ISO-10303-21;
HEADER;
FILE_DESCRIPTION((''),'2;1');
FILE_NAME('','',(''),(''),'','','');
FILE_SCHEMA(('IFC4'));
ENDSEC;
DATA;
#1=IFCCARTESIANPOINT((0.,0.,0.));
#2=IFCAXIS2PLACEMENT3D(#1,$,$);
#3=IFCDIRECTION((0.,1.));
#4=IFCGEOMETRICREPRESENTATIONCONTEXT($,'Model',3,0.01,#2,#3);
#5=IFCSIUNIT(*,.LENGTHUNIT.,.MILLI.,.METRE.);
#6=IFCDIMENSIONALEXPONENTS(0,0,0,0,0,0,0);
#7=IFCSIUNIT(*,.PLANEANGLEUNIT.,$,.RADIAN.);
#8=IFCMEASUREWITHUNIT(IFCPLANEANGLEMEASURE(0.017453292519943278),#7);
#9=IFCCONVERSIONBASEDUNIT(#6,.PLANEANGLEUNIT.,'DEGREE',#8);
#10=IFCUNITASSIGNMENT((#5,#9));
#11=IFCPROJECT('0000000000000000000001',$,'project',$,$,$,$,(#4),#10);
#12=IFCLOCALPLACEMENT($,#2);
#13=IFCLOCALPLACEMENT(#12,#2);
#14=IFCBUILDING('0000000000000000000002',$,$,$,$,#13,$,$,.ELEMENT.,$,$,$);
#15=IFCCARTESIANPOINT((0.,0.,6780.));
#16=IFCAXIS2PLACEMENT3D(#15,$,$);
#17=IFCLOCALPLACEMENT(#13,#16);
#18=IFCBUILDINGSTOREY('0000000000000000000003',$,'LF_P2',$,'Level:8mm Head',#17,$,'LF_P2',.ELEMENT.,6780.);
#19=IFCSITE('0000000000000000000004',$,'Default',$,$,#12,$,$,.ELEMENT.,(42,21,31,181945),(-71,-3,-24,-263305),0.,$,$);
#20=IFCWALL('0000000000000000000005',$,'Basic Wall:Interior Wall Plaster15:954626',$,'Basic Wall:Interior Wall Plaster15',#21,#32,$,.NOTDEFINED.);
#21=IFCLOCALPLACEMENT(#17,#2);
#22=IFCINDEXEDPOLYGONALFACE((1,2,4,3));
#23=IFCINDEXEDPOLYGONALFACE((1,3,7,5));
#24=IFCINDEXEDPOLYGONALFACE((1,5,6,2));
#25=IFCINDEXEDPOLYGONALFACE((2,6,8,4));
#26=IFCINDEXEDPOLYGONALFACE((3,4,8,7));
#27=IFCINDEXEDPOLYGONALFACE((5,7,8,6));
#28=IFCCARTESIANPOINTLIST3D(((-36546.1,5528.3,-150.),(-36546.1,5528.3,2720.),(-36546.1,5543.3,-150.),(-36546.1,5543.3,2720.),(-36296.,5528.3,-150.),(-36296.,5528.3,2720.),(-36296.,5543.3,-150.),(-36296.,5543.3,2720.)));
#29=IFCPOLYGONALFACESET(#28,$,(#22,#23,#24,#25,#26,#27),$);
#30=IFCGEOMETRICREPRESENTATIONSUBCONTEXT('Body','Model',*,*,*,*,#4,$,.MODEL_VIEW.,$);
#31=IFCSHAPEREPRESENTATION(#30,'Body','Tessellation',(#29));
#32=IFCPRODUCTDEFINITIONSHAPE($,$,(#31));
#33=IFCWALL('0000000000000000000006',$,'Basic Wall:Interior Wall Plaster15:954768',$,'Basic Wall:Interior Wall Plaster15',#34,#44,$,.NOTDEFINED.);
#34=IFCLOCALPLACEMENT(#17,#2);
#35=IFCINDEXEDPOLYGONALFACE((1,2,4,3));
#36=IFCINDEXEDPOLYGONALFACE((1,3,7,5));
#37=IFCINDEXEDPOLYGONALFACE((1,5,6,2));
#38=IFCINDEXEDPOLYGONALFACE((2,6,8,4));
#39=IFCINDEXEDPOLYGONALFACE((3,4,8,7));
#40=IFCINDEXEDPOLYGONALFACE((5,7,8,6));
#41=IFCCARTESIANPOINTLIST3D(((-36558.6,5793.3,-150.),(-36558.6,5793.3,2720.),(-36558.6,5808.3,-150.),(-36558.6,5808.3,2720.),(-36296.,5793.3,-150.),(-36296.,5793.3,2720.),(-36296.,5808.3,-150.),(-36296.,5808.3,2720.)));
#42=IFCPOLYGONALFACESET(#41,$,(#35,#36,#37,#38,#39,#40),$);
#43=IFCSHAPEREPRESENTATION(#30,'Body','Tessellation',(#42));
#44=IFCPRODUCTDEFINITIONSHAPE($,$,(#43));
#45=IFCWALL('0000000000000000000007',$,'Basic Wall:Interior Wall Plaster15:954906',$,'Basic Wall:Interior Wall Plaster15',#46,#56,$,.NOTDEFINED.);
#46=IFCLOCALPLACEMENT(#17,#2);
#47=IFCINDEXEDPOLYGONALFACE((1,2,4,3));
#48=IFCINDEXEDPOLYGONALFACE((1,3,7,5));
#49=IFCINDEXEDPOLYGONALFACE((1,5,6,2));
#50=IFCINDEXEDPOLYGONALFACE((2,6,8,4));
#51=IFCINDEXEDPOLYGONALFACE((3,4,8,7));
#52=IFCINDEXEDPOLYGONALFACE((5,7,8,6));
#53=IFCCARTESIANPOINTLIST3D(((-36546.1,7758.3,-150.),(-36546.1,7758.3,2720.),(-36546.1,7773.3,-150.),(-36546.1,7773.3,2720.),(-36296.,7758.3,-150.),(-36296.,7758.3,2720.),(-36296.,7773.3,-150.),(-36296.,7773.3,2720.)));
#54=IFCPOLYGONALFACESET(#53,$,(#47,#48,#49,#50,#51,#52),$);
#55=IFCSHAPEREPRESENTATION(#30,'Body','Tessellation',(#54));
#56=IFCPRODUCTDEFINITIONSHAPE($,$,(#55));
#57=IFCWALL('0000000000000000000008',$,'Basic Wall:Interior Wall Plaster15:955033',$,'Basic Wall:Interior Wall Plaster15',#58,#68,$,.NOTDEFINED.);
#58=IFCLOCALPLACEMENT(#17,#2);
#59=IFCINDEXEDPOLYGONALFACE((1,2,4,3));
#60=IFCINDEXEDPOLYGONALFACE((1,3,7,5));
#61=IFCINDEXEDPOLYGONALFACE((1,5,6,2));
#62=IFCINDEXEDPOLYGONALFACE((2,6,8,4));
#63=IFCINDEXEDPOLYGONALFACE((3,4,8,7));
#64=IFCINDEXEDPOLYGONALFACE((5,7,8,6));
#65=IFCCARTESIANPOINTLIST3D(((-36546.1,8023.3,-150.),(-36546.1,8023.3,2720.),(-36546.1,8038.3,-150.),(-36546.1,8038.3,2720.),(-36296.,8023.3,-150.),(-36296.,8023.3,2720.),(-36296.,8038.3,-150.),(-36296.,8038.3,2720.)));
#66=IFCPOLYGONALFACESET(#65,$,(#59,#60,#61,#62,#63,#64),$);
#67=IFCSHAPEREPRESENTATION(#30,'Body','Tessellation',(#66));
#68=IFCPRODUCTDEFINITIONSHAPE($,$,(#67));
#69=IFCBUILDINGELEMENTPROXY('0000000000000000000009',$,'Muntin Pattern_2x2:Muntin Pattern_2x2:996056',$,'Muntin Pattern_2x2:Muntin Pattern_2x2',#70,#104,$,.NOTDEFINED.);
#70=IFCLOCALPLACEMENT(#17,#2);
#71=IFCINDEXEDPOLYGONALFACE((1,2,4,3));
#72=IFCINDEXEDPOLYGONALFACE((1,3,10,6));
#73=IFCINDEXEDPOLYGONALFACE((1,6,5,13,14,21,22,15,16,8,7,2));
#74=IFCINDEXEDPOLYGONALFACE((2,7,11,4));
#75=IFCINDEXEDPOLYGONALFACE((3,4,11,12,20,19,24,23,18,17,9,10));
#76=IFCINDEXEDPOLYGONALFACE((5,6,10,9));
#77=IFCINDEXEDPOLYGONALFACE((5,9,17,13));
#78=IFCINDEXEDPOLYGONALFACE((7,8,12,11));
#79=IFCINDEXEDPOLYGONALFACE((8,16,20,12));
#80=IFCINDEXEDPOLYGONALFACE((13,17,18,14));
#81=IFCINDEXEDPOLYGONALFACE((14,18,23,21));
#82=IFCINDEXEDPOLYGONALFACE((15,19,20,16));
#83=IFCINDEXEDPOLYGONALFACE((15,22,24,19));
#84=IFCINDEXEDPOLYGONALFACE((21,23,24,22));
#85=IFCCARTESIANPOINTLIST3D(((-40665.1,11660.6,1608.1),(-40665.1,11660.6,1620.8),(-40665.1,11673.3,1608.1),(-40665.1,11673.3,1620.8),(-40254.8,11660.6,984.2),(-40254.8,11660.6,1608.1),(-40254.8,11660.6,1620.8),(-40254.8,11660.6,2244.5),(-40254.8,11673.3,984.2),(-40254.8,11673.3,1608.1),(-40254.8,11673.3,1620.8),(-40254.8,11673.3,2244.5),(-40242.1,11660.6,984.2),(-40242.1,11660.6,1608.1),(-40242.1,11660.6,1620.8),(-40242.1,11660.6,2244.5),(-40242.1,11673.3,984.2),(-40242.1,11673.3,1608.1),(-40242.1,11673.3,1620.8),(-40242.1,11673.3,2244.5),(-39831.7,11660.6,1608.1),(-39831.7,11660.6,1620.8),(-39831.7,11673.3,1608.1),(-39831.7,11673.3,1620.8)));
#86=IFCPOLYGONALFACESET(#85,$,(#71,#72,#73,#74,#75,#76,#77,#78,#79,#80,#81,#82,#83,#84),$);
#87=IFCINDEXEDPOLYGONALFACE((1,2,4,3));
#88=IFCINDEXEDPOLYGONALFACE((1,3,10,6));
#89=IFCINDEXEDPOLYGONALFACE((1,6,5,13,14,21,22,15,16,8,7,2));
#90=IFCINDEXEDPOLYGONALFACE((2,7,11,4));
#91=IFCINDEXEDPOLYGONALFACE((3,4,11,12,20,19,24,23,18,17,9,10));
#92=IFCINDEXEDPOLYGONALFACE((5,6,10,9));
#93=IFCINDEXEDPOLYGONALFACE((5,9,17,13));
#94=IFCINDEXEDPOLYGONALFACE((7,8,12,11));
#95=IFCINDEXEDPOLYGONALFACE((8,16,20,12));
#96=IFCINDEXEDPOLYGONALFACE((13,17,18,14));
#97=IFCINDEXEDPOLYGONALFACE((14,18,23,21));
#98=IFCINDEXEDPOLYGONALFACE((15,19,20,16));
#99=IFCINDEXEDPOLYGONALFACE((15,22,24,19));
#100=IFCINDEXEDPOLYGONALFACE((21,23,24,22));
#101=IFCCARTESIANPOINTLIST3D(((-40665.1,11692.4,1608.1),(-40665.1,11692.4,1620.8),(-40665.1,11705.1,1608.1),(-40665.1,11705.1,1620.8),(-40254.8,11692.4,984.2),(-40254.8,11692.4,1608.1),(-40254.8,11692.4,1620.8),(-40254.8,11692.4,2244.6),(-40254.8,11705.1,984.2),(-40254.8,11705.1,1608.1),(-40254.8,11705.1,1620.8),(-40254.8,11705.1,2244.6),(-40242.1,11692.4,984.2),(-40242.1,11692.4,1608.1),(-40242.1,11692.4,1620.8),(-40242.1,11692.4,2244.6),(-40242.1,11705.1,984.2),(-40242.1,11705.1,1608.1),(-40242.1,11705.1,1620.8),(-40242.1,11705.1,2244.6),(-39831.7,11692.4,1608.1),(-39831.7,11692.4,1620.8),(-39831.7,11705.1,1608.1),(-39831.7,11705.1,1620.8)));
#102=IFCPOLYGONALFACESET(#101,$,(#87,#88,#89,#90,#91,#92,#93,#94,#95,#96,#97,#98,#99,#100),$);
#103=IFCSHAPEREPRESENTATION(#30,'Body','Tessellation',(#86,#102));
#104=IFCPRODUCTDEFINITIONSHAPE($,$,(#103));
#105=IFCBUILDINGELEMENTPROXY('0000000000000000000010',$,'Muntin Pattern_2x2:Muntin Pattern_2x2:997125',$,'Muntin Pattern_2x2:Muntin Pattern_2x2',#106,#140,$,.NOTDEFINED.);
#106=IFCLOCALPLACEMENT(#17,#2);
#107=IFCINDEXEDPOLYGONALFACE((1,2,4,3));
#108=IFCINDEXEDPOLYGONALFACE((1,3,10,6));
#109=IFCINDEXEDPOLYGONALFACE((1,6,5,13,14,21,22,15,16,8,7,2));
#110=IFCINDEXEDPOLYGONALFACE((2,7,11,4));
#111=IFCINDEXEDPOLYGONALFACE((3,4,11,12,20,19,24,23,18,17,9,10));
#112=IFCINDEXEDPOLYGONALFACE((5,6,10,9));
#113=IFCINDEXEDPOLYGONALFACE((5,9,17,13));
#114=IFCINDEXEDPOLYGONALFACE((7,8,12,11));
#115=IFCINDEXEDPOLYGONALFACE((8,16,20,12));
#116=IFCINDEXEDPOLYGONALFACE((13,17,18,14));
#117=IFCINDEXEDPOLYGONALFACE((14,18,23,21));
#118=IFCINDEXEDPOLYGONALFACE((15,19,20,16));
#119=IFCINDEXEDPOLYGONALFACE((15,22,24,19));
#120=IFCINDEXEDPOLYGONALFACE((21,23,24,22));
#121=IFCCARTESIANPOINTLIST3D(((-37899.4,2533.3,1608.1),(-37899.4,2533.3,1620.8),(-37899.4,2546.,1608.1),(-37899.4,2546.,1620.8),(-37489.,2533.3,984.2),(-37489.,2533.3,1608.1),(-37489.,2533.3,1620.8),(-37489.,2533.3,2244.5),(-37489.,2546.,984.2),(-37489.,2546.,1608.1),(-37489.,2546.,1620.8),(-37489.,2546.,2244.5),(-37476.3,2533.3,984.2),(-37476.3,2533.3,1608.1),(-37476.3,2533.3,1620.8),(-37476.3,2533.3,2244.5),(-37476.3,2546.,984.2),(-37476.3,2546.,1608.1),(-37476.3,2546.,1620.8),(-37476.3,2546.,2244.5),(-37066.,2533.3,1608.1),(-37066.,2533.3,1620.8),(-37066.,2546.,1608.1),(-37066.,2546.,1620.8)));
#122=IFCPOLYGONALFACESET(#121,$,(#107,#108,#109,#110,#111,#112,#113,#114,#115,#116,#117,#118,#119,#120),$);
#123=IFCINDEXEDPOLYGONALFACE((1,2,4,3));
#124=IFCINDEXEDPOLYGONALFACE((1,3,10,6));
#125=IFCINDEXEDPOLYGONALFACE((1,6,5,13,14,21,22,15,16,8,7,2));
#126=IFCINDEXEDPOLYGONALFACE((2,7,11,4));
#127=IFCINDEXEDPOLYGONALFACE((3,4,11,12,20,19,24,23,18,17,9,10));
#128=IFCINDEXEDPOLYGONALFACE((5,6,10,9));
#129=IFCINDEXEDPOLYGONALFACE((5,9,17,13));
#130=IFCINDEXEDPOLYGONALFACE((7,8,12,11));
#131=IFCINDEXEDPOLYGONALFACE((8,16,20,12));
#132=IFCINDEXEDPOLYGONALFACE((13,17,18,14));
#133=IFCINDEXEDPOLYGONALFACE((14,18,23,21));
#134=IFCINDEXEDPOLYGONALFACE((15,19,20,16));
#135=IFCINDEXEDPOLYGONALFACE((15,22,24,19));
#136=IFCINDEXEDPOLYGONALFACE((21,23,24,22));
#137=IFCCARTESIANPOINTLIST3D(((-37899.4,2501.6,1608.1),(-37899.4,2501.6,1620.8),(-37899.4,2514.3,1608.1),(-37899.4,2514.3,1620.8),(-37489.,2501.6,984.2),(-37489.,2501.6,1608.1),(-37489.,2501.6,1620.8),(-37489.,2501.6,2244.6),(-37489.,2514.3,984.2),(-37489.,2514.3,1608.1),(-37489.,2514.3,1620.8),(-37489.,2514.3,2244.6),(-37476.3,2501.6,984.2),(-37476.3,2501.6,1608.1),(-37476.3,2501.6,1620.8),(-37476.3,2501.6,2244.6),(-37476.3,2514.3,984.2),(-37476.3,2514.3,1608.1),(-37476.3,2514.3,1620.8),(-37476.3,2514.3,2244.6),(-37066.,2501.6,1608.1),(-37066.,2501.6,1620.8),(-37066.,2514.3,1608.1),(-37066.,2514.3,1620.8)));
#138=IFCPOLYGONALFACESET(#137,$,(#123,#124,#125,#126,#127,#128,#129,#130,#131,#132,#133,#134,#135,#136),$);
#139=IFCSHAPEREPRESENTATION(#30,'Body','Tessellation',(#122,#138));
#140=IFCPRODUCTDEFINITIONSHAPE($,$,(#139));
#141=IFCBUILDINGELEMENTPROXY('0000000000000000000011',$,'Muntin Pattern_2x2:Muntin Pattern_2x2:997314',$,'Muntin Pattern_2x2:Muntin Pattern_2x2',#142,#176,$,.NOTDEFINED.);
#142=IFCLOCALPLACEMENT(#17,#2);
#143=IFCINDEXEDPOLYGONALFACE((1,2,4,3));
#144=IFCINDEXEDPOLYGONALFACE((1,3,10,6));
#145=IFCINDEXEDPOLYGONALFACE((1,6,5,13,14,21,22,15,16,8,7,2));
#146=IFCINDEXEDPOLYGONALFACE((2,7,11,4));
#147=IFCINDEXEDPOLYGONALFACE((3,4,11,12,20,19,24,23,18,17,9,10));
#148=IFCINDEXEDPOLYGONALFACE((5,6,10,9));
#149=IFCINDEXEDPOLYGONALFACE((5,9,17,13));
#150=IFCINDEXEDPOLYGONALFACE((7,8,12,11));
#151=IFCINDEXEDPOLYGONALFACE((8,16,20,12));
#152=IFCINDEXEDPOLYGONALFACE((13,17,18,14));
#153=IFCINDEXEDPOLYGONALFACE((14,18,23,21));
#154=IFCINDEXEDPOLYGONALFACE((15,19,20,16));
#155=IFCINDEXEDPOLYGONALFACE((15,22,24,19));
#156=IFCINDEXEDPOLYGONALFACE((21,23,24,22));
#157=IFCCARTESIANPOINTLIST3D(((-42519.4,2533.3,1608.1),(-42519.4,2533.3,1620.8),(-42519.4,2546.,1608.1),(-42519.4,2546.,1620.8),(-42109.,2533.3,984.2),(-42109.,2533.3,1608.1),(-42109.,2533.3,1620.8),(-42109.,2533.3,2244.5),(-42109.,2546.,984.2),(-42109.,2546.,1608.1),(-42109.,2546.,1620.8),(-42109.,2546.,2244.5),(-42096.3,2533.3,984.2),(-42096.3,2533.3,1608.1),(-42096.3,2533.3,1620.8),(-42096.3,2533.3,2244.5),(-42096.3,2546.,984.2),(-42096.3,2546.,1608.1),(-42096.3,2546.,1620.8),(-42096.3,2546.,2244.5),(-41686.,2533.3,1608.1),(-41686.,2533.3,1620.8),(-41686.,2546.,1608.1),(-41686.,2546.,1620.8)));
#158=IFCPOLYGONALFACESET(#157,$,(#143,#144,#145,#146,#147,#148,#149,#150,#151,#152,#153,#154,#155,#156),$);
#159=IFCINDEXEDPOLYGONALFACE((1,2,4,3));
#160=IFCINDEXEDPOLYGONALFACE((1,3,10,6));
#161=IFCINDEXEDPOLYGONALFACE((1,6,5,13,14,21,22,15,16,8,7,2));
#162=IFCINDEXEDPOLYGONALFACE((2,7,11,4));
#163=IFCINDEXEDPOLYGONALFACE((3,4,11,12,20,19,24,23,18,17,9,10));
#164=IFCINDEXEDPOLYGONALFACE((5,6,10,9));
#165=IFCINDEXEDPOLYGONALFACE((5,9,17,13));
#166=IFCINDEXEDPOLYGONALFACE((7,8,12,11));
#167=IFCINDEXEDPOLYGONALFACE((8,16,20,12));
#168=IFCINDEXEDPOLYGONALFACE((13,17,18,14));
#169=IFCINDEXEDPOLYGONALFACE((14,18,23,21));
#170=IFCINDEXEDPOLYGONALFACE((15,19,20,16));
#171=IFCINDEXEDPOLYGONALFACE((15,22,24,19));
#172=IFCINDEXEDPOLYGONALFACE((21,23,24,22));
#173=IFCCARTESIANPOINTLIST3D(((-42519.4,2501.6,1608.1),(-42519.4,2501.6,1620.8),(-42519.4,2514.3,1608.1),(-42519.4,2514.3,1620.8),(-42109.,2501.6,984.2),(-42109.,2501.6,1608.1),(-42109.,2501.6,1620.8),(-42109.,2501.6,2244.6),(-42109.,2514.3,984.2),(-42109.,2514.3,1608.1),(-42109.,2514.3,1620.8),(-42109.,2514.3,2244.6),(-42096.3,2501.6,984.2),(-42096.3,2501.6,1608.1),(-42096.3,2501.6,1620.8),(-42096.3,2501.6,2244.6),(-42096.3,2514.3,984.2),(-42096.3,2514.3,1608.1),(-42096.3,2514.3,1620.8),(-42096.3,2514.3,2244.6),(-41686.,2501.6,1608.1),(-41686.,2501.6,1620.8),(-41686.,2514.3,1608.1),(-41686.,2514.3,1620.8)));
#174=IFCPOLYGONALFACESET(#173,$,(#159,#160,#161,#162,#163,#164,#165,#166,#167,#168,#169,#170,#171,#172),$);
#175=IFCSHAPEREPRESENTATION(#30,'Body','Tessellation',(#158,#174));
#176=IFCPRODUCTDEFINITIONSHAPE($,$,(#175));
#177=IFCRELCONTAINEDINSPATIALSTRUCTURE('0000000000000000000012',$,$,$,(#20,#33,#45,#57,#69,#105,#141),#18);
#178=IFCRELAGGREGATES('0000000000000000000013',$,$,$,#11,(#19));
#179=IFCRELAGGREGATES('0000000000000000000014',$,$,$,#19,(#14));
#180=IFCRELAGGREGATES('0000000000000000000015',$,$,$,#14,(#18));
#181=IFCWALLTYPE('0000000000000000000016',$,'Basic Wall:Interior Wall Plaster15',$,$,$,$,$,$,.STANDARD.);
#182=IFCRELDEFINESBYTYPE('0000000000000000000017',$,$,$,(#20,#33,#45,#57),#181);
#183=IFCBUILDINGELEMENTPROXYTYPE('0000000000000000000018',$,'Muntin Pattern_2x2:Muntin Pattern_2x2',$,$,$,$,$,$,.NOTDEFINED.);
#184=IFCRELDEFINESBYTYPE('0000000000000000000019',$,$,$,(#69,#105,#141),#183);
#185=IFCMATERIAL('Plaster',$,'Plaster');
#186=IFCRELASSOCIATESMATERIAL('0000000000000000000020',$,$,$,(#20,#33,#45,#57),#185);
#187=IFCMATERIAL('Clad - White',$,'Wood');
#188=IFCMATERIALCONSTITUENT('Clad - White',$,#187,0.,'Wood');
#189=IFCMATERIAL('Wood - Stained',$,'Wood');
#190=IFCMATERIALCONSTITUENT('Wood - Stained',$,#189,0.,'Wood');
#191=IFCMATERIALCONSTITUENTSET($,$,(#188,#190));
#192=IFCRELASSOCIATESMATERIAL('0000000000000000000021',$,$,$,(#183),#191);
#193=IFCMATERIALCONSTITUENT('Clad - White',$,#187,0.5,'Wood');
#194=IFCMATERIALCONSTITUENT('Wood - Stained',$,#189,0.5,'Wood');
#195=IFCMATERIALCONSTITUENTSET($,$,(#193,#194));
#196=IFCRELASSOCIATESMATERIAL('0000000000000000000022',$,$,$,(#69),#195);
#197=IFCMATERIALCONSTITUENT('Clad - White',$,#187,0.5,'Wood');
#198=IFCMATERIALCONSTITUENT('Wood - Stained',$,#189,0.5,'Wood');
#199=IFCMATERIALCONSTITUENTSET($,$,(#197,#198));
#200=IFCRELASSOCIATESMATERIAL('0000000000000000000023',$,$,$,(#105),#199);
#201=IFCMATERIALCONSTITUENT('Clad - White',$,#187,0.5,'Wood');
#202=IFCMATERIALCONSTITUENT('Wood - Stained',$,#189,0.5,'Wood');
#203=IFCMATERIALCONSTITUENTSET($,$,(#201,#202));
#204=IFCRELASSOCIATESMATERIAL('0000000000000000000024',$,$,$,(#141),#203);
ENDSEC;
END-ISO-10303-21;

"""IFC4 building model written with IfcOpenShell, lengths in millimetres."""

from ifc_helpers import new_model, entity, si_unit, converted_unit, direction, frame, origin, place, context, subcontext, project, spatial, indexed_curve, outline, extrude, source, transform, mapped, material, constituent, constituent_set, type_object, type_shapes, element, save


model = new_model("IFC4")

# Units and contexts
model_context = context("Model", 3, precision=0.01, world=origin(), true_north=direction((0.0, 1.0)))
body_context = subcontext(model_context, "Body", "Model", "MODEL_VIEW")
ifc_project = project(units=[si_unit("LENGTHUNIT", "METRE", prefix="MILLI"), converted_unit("PLANEANGLEUNIT", "DEGREE", entity("IfcPlaneAngleMeasure", 0.017453292519943278), si_unit("PLANEANGLEUNIT", "RADIAN"), dimensions=[0, 0, 0, 0, 0, 0, 0])], contexts=[model_context])

# Site, building, storey
site_placement = place(None, origin())
site = spatial("IfcSite", under=ifc_project, at=site_placement, Name="Default", CompositionType="ELEMENT", RefLatitude=(42, 21, 31, 181945), RefLongitude=(-71, -3, -24, -263305), RefElevation=0.0)
building_placement = place(site_placement, origin())
building = spatial("IfcBuilding", under=site, at=building_placement, CompositionType="ELEMENT")
storey_placement = place(building_placement, frame((0.0, 0.0, 6780.0)))
storey = spatial("IfcBuildingStorey", under=building, at=storey_placement, Name="LF_P2", ObjectType="Level:8mm Head", LongName="LF_P2", CompositionType="ELEMENT", Elevation=6780.0)

# Walls
ifc_material_1 = material(Name="Plaster", Category="Plaster")
wall_type_1 = type_object("IfcWallType", Name="Basic Wall:Interior Wall Plaster15", PredefinedType="STANDARD")
wall_1_placement = place(storey_placement, frame((-36296.0, 5535.8, -150.0), z_axis=(0.0, 0.0, 1.0), x_axis=(-1.0, 0.0, 0.0)))
element("IfcWall", 1, at=wall_1_placement, inside=storey, type_object=wall_type_1, material=ifc_material_1, Name="Basic Wall:Interior Wall Plaster15:954626", ObjectType="Basic Wall:Interior Wall Plaster15", PredefinedType="NOTDEFINED", context=body_context, shape_type="SweptSolid", body=[
    extrude(outline(indexed_curve([(250.1, 7.5), (0.0, 7.5), (0.0, -7.5), (250.1, -7.5), (250.1, 7.5)], self_intersect=False)), origin(), (0.0, 0.0, 1.0), 2870.0),
])
wall_2_placement = place(storey_placement, frame((-36296.0, 5800.8, -150.0), z_axis=(0.0, 0.0, 1.0), x_axis=(-1.0, 0.0, 0.0)))
element("IfcWall", 2, at=wall_2_placement, inside=storey, type_object=wall_type_1, material=ifc_material_1, Name="Basic Wall:Interior Wall Plaster15:954768", ObjectType="Basic Wall:Interior Wall Plaster15", PredefinedType="NOTDEFINED", context=body_context, shape_type="SweptSolid", body=[
    extrude(outline(indexed_curve([(262.6, 7.5), (0.0, 7.5), (0.0, -7.5), (262.6, -7.5), (262.6, 7.5)], self_intersect=False)), origin(), (0.0, 0.0, 1.0), 2870.0),
])
wall_3_placement = place(storey_placement, frame((-36296.0, 7765.8, -150.0), z_axis=(0.0, 0.0, 1.0), x_axis=(-1.0, 0.0, 0.0)))
element("IfcWall", 3, at=wall_3_placement, inside=storey, type_object=wall_type_1, material=ifc_material_1, Name="Basic Wall:Interior Wall Plaster15:954906", ObjectType="Basic Wall:Interior Wall Plaster15", PredefinedType="NOTDEFINED", context=body_context, shape_type="SweptSolid", body=[
    extrude(outline(indexed_curve([(250.1, 7.5), (0.0, 7.5), (0.0, -7.5), (250.1, -7.5), (250.1, 7.5)], self_intersect=False)), origin(), (0.0, 0.0, 1.0), 2870.0),
])
wall_4_placement = place(storey_placement, frame((-36296.0, 8030.8, -150.0), z_axis=(0.0, 0.0, 1.0), x_axis=(-1.0, 0.0, 0.0)))
element("IfcWall", 4, at=wall_4_placement, inside=storey, type_object=wall_type_1, material=ifc_material_1, Name="Basic Wall:Interior Wall Plaster15:955033", ObjectType="Basic Wall:Interior Wall Plaster15", PredefinedType="NOTDEFINED", context=body_context, shape_type="SweptSolid", body=[
    extrude(outline(indexed_curve([(250.1, 7.5), (0.0, 7.5), (0.0, -7.5), (250.1, -7.5), (250.1, 7.5)], self_intersect=False)), origin(), (0.0, 0.0, 1.0), 2870.0),
])

# Building element proxies
ifc_material_2 = material(Name="Clad - White", Category="Wood")
ifc_constituent_1 = constituent(ifc_material_2, Name="Clad - White", Category="Wood", fraction=0.5)
ifc_material_3 = material(Name="Wood - Stained", Category="Wood")
ifc_constituent_2 = constituent(ifc_material_3, Name="Wood - Stained", Category="Wood", fraction=0.5)
ifc_constituent_set_1 = constituent_set(constituents=[ifc_constituent_1, ifc_constituent_2])
ifc_constituent_3 = constituent(ifc_material_2, Name="Clad - White", Category="Wood", fraction=0.0)
ifc_constituent_4 = constituent(ifc_material_3, Name="Wood - Stained", Category="Wood", fraction=0.0)
ifc_constituent_set_2 = constituent_set(constituents=[ifc_constituent_3, ifc_constituent_4])
building_element_proxy_type_1 = type_object("IfcBuildingElementProxyType", Name="Muntin Pattern_2x2:Muntin Pattern_2x2", PredefinedType="NOTDEFINED", material=ifc_constituent_set_2)
shared_shape_1 = source(origin(), body_context, "Body", "SweptSolid", [
    extrude(outline(indexed_curve([(6.4, -6.4), (630.1, -6.4), (630.1, 6.3), (6.4, 6.3), (6.4, 416.7), (-6.3, 416.7), (-6.3, 6.3), (-630.2, 6.3), (-630.2, -6.4), (-6.3, -6.4), (-6.3, -416.7), (6.4, -416.7), (6.4, -6.4)], self_intersect=False)), frame((0.0, -22.2, 630.1), z_axis=(0.0, 1.0, 0.0), x_axis=(0.0, 0.0, 1.0)), (0.0, 0.0, 1.0), 12.7),
    extrude(outline(indexed_curve([(6.4, -6.4), (630.2, -6.4), (630.2, 6.3), (6.4, 6.3), (6.4, 416.7), (-6.3, 416.7), (-6.3, 6.3), (-630.2, 6.3), (-630.2, -6.4), (-6.3, -6.4), (-6.3, -416.7), (6.4, -416.7), (6.4, -6.4)], self_intersect=False)), frame((0.0, 9.5, 630.2), z_axis=(0.0, 1.0, 0.0), x_axis=(0.0, 0.0, 1.0)), (0.0, 0.0, 1.0), 12.7),
])
type_shapes(building_element_proxy_type_1, [shared_shape_1])
proxy_1_placement = place(storey_placement, frame((-40248.4, 11682.9, 984.3)))
element("IfcBuildingElementProxy", 5, at=proxy_1_placement, inside=storey, type_object=building_element_proxy_type_1, material=ifc_constituent_set_1, Name="Muntin Pattern_2x2:Muntin Pattern_2x2:996056", ObjectType="Muntin Pattern_2x2:Muntin Pattern_2x2", PredefinedType="NOTDEFINED", context=body_context, shape_type="MappedRepresentation", body=[
    mapped(shared_shape_1, transform((0.0, 0.0, 0.0), scale=1.0)),
])
ifc_constituent_5 = constituent(ifc_material_2, Name="Clad - White", Category="Wood", fraction=0.5)
ifc_constituent_6 = constituent(ifc_material_3, Name="Wood - Stained", Category="Wood", fraction=0.5)
ifc_constituent_set_3 = constituent_set(constituents=[ifc_constituent_5, ifc_constituent_6])
proxy_2_placement = place(storey_placement, frame((-37482.7, 2523.8, 984.3), z_axis=(0.0, 0.0, 1.0), x_axis=(-1.0, 0.0, 0.0)))
element("IfcBuildingElementProxy", 6, at=proxy_2_placement, inside=storey, type_object=building_element_proxy_type_1, material=ifc_constituent_set_3, Name="Muntin Pattern_2x2:Muntin Pattern_2x2:997125", ObjectType="Muntin Pattern_2x2:Muntin Pattern_2x2", PredefinedType="NOTDEFINED", context=body_context, shape_type="MappedRepresentation", body=[
    mapped(shared_shape_1, transform((0.0, 0.0, 0.0), scale=1.0)),
])
ifc_constituent_7 = constituent(ifc_material_2, Name="Clad - White", Category="Wood", fraction=0.5)
ifc_constituent_8 = constituent(ifc_material_3, Name="Wood - Stained", Category="Wood", fraction=0.5)
ifc_constituent_set_4 = constituent_set(constituents=[ifc_constituent_7, ifc_constituent_8])
proxy_3_placement = place(storey_placement, frame((-42102.7, 2523.8, 984.3), z_axis=(0.0, 0.0, 1.0), x_axis=(-1.0, 0.0, 0.0)))
element("IfcBuildingElementProxy", 7, at=proxy_3_placement, inside=storey, type_object=building_element_proxy_type_1, material=ifc_constituent_set_4, Name="Muntin Pattern_2x2:Muntin Pattern_2x2:997314", ObjectType="Muntin Pattern_2x2:Muntin Pattern_2x2", PredefinedType="NOTDEFINED", context=body_context, shape_type="MappedRepresentation", body=[
    mapped(shared_shape_1, transform((0.0, 0.0, 0.0), scale=1.0)),
])

save(model, "model.ifc")
